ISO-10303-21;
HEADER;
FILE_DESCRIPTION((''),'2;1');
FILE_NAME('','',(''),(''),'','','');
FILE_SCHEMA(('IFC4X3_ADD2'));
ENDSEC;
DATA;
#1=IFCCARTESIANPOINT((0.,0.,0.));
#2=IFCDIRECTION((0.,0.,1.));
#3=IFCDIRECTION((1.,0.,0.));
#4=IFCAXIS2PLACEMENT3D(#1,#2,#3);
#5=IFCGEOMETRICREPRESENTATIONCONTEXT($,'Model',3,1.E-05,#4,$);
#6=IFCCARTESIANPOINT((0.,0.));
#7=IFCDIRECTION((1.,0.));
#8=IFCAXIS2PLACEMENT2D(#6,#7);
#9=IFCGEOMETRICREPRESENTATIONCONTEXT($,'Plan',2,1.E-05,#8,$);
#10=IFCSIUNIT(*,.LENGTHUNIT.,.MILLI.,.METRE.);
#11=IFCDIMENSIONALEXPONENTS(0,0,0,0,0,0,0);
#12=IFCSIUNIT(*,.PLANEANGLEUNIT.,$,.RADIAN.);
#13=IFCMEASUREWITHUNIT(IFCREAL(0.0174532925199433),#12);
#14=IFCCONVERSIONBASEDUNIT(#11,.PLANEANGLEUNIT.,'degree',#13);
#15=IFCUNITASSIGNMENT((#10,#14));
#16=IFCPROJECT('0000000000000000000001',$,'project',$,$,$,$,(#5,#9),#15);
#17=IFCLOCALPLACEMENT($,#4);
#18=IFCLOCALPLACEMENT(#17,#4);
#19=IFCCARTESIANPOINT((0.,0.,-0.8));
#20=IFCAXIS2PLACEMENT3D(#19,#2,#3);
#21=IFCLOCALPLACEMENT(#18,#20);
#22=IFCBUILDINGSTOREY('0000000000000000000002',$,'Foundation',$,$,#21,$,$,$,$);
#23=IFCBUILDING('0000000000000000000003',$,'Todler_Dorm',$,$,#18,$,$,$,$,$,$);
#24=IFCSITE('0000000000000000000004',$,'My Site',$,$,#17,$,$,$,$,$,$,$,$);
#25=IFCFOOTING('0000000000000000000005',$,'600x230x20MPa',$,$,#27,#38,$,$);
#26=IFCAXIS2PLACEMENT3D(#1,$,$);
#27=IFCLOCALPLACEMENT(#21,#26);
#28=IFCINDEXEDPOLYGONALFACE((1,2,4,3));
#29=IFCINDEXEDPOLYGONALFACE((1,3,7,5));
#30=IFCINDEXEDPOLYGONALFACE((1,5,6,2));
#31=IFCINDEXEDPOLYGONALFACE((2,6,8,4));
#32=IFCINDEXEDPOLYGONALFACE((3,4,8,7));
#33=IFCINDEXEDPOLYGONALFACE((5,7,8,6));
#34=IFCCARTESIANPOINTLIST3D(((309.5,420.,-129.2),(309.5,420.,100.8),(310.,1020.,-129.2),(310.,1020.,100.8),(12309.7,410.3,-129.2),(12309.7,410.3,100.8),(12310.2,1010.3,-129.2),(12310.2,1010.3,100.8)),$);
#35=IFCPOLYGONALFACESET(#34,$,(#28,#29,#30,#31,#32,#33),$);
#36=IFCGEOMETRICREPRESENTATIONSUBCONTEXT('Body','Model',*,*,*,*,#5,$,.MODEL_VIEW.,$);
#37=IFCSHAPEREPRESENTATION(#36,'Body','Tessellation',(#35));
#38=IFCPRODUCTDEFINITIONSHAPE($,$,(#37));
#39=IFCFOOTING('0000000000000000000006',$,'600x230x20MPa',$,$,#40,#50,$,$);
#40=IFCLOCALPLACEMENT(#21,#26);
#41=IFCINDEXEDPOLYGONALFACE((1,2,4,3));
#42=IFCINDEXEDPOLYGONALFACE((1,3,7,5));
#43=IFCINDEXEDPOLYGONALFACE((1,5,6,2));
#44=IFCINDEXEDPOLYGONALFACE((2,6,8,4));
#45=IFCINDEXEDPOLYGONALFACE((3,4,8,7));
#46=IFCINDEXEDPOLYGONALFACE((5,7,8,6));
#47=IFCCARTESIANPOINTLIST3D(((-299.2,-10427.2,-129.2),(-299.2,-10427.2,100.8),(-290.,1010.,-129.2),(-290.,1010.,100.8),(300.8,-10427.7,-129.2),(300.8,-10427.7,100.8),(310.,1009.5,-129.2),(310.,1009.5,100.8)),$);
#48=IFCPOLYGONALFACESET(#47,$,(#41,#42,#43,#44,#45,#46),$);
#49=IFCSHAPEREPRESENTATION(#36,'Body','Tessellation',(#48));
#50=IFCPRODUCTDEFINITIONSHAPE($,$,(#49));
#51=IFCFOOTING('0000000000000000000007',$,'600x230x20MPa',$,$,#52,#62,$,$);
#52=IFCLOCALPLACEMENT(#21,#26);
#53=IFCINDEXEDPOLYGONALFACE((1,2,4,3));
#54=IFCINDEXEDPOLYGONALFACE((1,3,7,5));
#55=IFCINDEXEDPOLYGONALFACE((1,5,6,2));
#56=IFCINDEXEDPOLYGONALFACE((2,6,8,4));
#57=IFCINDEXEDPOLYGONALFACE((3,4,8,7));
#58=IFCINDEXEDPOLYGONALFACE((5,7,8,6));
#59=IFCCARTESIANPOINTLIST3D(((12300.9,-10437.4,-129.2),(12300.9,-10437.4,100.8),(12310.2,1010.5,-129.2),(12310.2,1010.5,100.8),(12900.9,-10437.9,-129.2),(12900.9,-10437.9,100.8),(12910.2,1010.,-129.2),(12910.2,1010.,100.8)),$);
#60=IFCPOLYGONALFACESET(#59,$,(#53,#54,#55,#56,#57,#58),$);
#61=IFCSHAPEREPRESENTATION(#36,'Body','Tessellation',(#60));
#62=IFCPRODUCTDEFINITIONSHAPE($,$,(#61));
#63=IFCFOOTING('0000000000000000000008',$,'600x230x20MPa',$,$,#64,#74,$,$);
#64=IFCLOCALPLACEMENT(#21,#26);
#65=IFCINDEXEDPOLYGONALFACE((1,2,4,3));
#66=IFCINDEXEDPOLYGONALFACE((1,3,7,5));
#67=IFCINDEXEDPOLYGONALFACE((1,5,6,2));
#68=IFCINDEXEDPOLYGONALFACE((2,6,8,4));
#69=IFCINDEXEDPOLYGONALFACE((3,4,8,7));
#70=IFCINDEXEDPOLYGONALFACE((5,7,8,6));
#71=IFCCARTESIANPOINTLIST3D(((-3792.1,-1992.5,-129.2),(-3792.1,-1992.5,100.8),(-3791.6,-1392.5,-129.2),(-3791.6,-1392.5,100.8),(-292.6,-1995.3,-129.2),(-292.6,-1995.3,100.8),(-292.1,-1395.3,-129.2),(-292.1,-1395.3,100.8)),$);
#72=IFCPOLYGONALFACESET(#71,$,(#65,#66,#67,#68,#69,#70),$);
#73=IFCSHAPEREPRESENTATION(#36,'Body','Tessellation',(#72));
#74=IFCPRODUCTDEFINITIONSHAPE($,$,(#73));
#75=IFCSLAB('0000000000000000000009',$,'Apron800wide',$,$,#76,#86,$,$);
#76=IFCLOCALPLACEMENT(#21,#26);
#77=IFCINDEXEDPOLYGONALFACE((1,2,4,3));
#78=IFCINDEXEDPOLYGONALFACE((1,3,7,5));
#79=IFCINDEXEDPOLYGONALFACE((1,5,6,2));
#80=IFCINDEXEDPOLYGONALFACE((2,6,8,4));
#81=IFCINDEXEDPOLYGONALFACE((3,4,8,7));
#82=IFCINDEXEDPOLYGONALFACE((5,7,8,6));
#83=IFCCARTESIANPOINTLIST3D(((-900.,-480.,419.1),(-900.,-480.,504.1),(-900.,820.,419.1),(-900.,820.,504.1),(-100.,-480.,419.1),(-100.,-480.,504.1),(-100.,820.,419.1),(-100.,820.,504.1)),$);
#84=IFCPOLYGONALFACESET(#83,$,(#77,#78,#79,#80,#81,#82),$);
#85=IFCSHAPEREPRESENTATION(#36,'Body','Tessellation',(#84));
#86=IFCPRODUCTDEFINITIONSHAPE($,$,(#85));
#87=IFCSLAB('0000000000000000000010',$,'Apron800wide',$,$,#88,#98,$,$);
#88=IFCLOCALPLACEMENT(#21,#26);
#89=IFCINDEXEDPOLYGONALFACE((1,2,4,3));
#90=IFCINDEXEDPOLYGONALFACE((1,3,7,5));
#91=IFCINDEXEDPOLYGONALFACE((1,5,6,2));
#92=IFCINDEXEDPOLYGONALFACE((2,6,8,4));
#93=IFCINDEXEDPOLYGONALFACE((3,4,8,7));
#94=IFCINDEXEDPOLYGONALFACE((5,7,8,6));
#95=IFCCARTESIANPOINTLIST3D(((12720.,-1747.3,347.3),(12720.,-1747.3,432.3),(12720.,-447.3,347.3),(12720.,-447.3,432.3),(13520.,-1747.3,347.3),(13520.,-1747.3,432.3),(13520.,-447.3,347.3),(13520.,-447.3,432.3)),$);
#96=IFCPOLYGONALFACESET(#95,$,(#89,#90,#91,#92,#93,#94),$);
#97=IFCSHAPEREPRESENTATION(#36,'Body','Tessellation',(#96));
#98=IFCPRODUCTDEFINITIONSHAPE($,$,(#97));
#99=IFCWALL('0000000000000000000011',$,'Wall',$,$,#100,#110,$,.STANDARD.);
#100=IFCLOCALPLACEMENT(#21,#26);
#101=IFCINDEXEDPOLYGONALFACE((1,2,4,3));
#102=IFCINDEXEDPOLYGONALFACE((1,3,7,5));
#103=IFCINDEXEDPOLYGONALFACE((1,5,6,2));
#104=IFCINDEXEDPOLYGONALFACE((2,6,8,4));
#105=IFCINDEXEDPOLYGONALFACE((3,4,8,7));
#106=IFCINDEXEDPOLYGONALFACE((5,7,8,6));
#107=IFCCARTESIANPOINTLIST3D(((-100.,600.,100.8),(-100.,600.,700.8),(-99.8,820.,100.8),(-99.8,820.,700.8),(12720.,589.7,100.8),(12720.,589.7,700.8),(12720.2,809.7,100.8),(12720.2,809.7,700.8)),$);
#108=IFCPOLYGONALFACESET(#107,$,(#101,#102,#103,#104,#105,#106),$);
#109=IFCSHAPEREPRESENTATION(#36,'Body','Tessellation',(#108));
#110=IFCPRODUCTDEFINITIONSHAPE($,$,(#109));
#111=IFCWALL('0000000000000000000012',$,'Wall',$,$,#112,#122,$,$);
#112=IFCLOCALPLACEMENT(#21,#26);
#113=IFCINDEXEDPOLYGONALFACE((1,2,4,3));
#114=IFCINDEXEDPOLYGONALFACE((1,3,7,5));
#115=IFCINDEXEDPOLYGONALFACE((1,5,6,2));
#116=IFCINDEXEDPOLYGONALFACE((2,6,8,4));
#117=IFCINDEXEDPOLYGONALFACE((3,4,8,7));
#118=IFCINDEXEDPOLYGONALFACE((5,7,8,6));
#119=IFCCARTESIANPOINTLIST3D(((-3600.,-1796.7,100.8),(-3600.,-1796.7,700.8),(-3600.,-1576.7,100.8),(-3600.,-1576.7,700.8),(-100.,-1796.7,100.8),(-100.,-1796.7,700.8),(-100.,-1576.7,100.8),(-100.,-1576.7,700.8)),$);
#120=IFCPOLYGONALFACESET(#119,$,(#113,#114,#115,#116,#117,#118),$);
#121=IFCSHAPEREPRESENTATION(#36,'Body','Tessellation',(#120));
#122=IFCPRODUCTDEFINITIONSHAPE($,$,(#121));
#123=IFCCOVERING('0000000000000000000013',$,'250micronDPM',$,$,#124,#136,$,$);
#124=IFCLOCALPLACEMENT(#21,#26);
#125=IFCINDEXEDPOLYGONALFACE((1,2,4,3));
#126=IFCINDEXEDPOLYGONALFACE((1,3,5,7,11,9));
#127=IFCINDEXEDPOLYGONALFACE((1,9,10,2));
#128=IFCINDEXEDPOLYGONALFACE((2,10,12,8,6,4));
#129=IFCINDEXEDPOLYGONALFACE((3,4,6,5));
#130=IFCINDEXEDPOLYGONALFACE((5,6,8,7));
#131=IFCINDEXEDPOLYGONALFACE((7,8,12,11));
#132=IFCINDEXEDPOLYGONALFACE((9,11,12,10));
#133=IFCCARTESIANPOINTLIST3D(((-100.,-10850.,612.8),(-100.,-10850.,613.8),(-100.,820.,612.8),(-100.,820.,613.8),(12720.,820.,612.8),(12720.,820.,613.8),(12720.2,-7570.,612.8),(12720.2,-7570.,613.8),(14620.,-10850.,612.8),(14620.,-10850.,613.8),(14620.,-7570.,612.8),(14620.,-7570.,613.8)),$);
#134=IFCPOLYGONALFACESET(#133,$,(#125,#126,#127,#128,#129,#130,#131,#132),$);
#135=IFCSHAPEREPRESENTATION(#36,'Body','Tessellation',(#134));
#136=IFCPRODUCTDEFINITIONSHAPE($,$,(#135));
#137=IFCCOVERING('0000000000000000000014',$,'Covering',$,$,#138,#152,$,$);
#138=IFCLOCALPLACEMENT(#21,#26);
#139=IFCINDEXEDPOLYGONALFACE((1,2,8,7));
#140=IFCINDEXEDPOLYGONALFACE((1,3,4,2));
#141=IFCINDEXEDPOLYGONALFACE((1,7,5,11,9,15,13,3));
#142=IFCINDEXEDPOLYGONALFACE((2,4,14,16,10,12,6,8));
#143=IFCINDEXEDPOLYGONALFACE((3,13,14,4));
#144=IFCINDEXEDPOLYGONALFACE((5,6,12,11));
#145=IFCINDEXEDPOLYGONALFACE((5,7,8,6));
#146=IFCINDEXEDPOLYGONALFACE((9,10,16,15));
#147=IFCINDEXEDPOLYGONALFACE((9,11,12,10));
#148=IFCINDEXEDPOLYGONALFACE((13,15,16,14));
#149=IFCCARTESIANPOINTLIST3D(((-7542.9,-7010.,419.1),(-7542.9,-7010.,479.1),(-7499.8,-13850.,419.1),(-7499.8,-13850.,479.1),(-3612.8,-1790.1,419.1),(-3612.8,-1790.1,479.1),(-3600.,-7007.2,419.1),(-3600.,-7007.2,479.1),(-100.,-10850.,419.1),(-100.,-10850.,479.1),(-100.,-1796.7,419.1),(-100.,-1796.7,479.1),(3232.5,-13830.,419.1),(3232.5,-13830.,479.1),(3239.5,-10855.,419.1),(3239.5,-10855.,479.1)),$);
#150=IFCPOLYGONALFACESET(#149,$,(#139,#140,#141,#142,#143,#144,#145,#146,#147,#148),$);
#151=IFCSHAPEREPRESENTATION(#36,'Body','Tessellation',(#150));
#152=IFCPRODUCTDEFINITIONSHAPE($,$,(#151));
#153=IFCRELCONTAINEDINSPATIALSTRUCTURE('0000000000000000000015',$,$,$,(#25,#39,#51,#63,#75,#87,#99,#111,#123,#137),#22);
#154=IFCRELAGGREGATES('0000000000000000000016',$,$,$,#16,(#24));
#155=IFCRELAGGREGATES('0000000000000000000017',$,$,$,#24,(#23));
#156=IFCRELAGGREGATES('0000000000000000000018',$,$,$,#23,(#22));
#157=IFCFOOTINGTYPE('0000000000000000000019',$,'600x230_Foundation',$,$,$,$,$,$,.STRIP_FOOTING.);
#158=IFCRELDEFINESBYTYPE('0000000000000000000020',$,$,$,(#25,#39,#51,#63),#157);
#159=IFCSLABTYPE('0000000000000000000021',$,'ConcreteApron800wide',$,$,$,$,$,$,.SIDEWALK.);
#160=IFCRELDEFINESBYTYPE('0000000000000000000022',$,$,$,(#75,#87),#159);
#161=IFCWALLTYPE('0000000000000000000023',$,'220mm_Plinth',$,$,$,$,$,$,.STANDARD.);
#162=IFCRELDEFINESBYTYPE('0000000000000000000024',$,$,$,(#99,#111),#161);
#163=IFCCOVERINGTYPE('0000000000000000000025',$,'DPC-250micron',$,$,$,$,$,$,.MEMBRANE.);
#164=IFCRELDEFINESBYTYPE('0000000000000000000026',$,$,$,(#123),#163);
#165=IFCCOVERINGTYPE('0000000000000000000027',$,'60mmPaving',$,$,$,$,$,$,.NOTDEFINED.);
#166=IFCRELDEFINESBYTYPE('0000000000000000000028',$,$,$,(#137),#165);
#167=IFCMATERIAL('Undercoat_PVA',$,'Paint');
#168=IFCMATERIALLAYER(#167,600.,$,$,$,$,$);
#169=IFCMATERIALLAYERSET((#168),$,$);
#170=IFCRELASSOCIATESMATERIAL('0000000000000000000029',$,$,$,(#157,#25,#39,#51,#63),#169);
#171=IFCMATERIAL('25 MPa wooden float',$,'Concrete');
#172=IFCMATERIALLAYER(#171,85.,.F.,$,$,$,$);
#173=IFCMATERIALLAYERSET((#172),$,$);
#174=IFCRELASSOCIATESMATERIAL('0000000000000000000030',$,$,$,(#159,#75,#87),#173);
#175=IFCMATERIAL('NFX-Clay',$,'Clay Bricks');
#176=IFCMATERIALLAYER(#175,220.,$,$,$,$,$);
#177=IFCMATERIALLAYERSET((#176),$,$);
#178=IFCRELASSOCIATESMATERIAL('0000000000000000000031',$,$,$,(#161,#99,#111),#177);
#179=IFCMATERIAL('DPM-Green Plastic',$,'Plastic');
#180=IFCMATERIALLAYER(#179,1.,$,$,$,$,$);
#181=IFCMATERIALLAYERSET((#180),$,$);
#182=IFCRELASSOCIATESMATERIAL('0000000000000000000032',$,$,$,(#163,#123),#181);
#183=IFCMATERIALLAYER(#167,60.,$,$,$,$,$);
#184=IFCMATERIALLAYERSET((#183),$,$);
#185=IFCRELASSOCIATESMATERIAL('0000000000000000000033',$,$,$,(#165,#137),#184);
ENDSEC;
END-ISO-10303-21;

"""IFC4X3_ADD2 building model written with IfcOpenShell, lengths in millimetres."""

from ifc_helpers import new_model, entity, si_unit, converted_unit, frame, origin_with_axes, origin_2d_with_axis, place, context, subcontext, project, spatial, line, indexed_curve, outline, extrude, material, layer, layer_set, layer_usage, type_object, element, save


model = new_model("IFC4X3_ADD2")

# Units and contexts
model_context = context("Model", 3, precision=1e-05, world=origin_with_axes())
plan_context = context("Plan", 2, precision=1e-05, world=origin_2d_with_axis())
body_context = subcontext(model_context, "Body", "Model", "MODEL_VIEW")
ifc_project = project(units=[si_unit("LENGTHUNIT", "METRE", prefix="MILLI"), converted_unit("PLANEANGLEUNIT", "degree", entity("IfcReal", 0.0174532925199433), si_unit("PLANEANGLEUNIT", "RADIAN"), dimensions=[0, 0, 0, 0, 0, 0, 0])], contexts=[model_context, plan_context])

# Site, building, storey
site_placement = place(None, origin_with_axes())
site = spatial("IfcSite", under=ifc_project, at=site_placement, Name="My Site")
building_placement = place(site_placement, origin_with_axes())
building = spatial("IfcBuilding", under=site, at=building_placement, Name="Todler_Dorm")
storey_placement = place(building_placement, frame((0.0, 0.0, -0.8), z_axis=(0.0, 0.0, 1.0), x_axis=(1.0, 0.0, 0.0)))
storey = spatial("IfcBuildingStorey", under=building, at=storey_placement, Name="Foundation")

# Footings
ifc_material_1 = material(Name="Undercoat_PVA", Category="Paint")
ifc_layer_1 = layer(ifc_material_1, 600.0)
ifc_layer_set_1 = layer_set([ifc_layer_1])
ifc_layer_usage_1 = layer_usage(ifc_layer_set_1, "AXIS2", "POSITIVE", 0.0)
footing_type = type_object("IfcFootingType", Name="600x230_Foundation", PredefinedType="STRIP_FOOTING", material=ifc_layer_set_1)
footing_1_placement = place(storey_placement, frame((12310.2, 1010.3, -129.2), z_axis=(0.0, 0.0, 1.0), x_axis=(-1.0, 0.000807, 0.0)))
element("IfcFooting", 1, at=footing_1_placement, inside=storey, type_object=footing_type, material=ifc_layer_usage_1, Name="600x230x20MPa", context=body_context, shape_type="SweptSolid", body=[
    extrude(outline(indexed_curve([(0.0, 0.0), (0.0, 600.0), (12000.2, 600.0), (12000.2, 0.0)], segments=[line(1, 2, 3, 4, 1)])), origin_with_axes(), (0.0, 0.0, 1.0), 230.0),
])
ifc_layer_usage_2 = layer_usage(ifc_layer_set_1, "AXIS2", "POSITIVE", 0.0)
footing_2_placement = place(storey_placement, frame((-290.0, 1010.0, -129.2), z_axis=(0.0, 0.0, 1.0), x_axis=(-0.000807, -1.0, 0.0)))
element("IfcFooting", 2, at=footing_2_placement, inside=storey, type_object=footing_type, material=ifc_layer_usage_2, Name="600x230x20MPa", context=body_context, shape_type="SweptSolid", body=[
    extrude(outline(indexed_curve([(0.0, 0.0), (0.0, 600.0), (11437.2, 600.0), (11437.2, 0.0)], segments=[line(1, 2, 3, 4, 1)])), origin_with_axes(), (0.0, 0.0, 1.0), 230.0),
])
ifc_layer_usage_3 = layer_usage(ifc_layer_set_1, "AXIS2", "POSITIVE", 0.0)
footing_3_placement = place(storey_placement, frame((12310.2, 1010.5, -129.2), z_axis=(0.0, 0.0, 1.0), x_axis=(-0.000807, -1.0, 0.0)))
element("IfcFooting", 3, at=footing_3_placement, inside=storey, type_object=footing_type, material=ifc_layer_usage_3, Name="600x230x20MPa", context=body_context, shape_type="SweptSolid", body=[
    extrude(outline(indexed_curve([(0.0, 0.0), (0.0, 600.0), (11447.9, 600.0), (11447.9, 0.0)], segments=[line(1, 2, 3, 4, 1)])), origin_with_axes(), (0.0, 0.0, 1.0), 230.0),
])
ifc_layer_usage_4 = layer_usage(ifc_layer_set_1, "AXIS2", "POSITIVE", 0.0)
footing_4_placement = place(storey_placement, frame((-3792.1, -1992.5, -129.2), z_axis=(0.0, 0.0, 1.0), x_axis=(1.0, -0.000807, 0.0)))
element("IfcFooting", 4, at=footing_4_placement, inside=storey, type_object=footing_type, material=ifc_layer_usage_4, Name="600x230x20MPa", context=body_context, shape_type="SweptSolid", body=[
    extrude(outline(indexed_curve([(0.0, 0.0), (0.0, 600.0), (3499.5, 600.0), (3499.5, 0.0)], segments=[line(1, 2, 3, 4, 1)])), origin_with_axes(), (0.0, 0.0, 1.0), 230.0),
])

# Slabs
ifc_material_2 = material(Name="25 MPa wooden float", Category="Concrete")
ifc_layer_2 = layer(ifc_material_2, 85.0, ventilated=False)
ifc_layer_set_2 = layer_set([ifc_layer_2])
slab_type = type_object("IfcSlabType", Name="ConcreteApron800wide", PredefinedType="SIDEWALK", material=ifc_layer_set_2)
ifc_layer_usage_5 = layer_usage(ifc_layer_set_2, "AXIS3", "POSITIVE", -100.0)
slab_1_placement = place(storey_placement, frame((-100.0, 820.0, 519.1), z_axis=(0.0, 0.0, 1.0), x_axis=(0.0, 1.0, 0.0)))
element("IfcSlab", 5, at=slab_1_placement, inside=storey, type_object=slab_type, material=ifc_layer_usage_5, Name="Apron800wide", context=body_context, shape_type="SweptSolid", body=[
    extrude(outline(indexed_curve([(-1300.0, 0.0), (-1300.0, 800.0), (0.0, 800.0), (0.0, 0.0), (-1300.0, 0.0)])), frame((0.0, 0.0, -100.0), z_axis=(0.0, 0.0, 1.0), x_axis=(1.0, 0.0, 0.0)), (0.0, 0.0, 1.0), 85.0),
])
ifc_layer_usage_6 = layer_usage(ifc_layer_set_2, "AXIS3", "POSITIVE", -100.0)
slab_2_placement = place(storey_placement, frame((12720.0, -1747.3, 447.3), z_axis=(0.0, 0.0, 1.0), x_axis=(0.000001, -1.0, 0.0)))
element("IfcSlab", 6, at=slab_2_placement, inside=storey, type_object=slab_type, material=ifc_layer_usage_6, Name="Apron800wide", context=body_context, shape_type="SweptSolid", body=[
    extrude(outline(indexed_curve([(0.0, 0.0), (0.0, 800.0), (-1300.0, 800.0), (-1300.0, 0.0), (0.0, 0.0)])), frame((0.0, 0.0, -100.0), z_axis=(0.0, 0.0, 1.0), x_axis=(1.0, 0.0, 0.0)), (0.0, 0.0, 1.0), 85.0),
])

# Walls
ifc_material_3 = material(Name="NFX-Clay", Category="Clay Bricks")
ifc_layer_3 = layer(ifc_material_3, 220.0)
ifc_layer_set_3 = layer_set([ifc_layer_3])
ifc_layer_usage_7 = layer_usage(ifc_layer_set_3, "AXIS2", "POSITIVE", 0.0)
wall_type = type_object("IfcWallType", Name="220mm_Plinth", PredefinedType="STANDARD", material=ifc_layer_set_3)
wall_1_placement = place(storey_placement, frame((-100.0, 600.0, 100.8), z_axis=(0.0, 0.0, 1.0), x_axis=(1.0, -0.000807, 0.0)))
element("IfcWall", 7, at=wall_1_placement, inside=storey, type_object=wall_type, material=ifc_layer_usage_7, Name="Wall", PredefinedType="STANDARD", context=body_context, shape_type="SweptSolid", body=[
    extrude(outline(indexed_curve([(0.0, 0.0), (0.0, 220.0), (12820.0, 220.0), (12820.0, 0.0)], segments=[line(1, 2, 3, 4, 1)])), origin_with_axes(), (0.0, 0.0, 1.0), 600.0),
])
ifc_layer_usage_8 = layer_usage(ifc_layer_set_3, "AXIS2", "POSITIVE", 0.0)
wall_2_placement = place(storey_placement, frame((-3600.0, -1796.7, 100.8), z_axis=(0.0, 0.0, 1.0), x_axis=(1.0, 0.0, 0.0)))
element("IfcWall", 8, at=wall_2_placement, inside=storey, type_object=wall_type, material=ifc_layer_usage_8, Name="Wall", context=body_context, shape_type="SweptSolid", body=[
    extrude(outline(indexed_curve([(0.0, 0.0), (0.0, 220.0), (3500.0, 220.0), (3500.0, 0.0)], segments=[line(1, 2, 3, 4, 1)])), origin_with_axes(), (0.0, 0.0, 1.0), 600.0),
])

# Coverings
ifc_material_4 = material(Name="DPM-Green Plastic", Category="Plastic")
ifc_layer_4 = layer(ifc_material_4, 1.0)
ifc_layer_set_4 = layer_set([ifc_layer_4])
ifc_layer_usage_9 = layer_usage(ifc_layer_set_4, "AXIS3", "POSITIVE", -1.0)
covering_type_1 = type_object("IfcCoveringType", Name="DPC-250micron", PredefinedType="MEMBRANE", material=ifc_layer_set_4)
covering_1_placement = place(storey_placement, frame((-100.0, 820.0, 613.8), z_axis=(0.0, 0.0, 1.0), x_axis=(1.0, 0.0, 0.0)))
element("IfcCovering", 9, at=covering_1_placement, inside=storey, type_object=covering_type_1, material=ifc_layer_usage_9, Name="250micronDPM", context=body_context, shape_type="SweptSolid", body=[
    extrude(outline(indexed_curve([(0.0, 0.0), (12820.0, 0.0), (12820.2, -8390.0), (14720.0, -8390.0), (14720.0, -11670.0), (0.0, -11670.0), (0.0, 0.0)])), frame((0.0, 0.0, -1.0), z_axis=(0.0, 0.0, 1.0), x_axis=(1.0, 0.0, 0.0)), (0.0, 0.0, 1.0), 1.0),
])
ifc_layer_5 = layer(ifc_material_1, 60.0)
ifc_layer_set_5 = layer_set([ifc_layer_5])
ifc_layer_usage_10 = layer_usage(ifc_layer_set_5, "AXIS3", "POSITIVE", -60.0)
covering_type_2 = type_object("IfcCoveringType", Name="60mmPaving", PredefinedType="NOTDEFINED", material=ifc_layer_set_5)
covering_2_placement = place(storey_placement, frame((-3612.8, -1790.1, 479.1), z_axis=(0.0, 0.0, 1.0), x_axis=(1.0, 0.0, 0.0)))
element("IfcCovering", 10, at=covering_2_placement, inside=storey, type_object=covering_type_2, material=ifc_layer_usage_10, Name="Covering", context=body_context, shape_type="SweptSolid", body=[
    extrude(outline(indexed_curve([(12.8, -5217.1), (-3930.1, -5219.9), (-3887.0, -12060.0), (6845.3, -12039.9), (6852.3, -9064.9), (3512.8, -9059.9), (3512.8, -6.6), (0.0, 0.0), (12.8, -5217.1)])), frame((0.0, 0.0, -60.0), z_axis=(0.0, 0.0, 1.0), x_axis=(1.0, 0.0, 0.0)), (0.0, 0.0, 1.0), 60.0),
])

save(model, "model.ifc")
